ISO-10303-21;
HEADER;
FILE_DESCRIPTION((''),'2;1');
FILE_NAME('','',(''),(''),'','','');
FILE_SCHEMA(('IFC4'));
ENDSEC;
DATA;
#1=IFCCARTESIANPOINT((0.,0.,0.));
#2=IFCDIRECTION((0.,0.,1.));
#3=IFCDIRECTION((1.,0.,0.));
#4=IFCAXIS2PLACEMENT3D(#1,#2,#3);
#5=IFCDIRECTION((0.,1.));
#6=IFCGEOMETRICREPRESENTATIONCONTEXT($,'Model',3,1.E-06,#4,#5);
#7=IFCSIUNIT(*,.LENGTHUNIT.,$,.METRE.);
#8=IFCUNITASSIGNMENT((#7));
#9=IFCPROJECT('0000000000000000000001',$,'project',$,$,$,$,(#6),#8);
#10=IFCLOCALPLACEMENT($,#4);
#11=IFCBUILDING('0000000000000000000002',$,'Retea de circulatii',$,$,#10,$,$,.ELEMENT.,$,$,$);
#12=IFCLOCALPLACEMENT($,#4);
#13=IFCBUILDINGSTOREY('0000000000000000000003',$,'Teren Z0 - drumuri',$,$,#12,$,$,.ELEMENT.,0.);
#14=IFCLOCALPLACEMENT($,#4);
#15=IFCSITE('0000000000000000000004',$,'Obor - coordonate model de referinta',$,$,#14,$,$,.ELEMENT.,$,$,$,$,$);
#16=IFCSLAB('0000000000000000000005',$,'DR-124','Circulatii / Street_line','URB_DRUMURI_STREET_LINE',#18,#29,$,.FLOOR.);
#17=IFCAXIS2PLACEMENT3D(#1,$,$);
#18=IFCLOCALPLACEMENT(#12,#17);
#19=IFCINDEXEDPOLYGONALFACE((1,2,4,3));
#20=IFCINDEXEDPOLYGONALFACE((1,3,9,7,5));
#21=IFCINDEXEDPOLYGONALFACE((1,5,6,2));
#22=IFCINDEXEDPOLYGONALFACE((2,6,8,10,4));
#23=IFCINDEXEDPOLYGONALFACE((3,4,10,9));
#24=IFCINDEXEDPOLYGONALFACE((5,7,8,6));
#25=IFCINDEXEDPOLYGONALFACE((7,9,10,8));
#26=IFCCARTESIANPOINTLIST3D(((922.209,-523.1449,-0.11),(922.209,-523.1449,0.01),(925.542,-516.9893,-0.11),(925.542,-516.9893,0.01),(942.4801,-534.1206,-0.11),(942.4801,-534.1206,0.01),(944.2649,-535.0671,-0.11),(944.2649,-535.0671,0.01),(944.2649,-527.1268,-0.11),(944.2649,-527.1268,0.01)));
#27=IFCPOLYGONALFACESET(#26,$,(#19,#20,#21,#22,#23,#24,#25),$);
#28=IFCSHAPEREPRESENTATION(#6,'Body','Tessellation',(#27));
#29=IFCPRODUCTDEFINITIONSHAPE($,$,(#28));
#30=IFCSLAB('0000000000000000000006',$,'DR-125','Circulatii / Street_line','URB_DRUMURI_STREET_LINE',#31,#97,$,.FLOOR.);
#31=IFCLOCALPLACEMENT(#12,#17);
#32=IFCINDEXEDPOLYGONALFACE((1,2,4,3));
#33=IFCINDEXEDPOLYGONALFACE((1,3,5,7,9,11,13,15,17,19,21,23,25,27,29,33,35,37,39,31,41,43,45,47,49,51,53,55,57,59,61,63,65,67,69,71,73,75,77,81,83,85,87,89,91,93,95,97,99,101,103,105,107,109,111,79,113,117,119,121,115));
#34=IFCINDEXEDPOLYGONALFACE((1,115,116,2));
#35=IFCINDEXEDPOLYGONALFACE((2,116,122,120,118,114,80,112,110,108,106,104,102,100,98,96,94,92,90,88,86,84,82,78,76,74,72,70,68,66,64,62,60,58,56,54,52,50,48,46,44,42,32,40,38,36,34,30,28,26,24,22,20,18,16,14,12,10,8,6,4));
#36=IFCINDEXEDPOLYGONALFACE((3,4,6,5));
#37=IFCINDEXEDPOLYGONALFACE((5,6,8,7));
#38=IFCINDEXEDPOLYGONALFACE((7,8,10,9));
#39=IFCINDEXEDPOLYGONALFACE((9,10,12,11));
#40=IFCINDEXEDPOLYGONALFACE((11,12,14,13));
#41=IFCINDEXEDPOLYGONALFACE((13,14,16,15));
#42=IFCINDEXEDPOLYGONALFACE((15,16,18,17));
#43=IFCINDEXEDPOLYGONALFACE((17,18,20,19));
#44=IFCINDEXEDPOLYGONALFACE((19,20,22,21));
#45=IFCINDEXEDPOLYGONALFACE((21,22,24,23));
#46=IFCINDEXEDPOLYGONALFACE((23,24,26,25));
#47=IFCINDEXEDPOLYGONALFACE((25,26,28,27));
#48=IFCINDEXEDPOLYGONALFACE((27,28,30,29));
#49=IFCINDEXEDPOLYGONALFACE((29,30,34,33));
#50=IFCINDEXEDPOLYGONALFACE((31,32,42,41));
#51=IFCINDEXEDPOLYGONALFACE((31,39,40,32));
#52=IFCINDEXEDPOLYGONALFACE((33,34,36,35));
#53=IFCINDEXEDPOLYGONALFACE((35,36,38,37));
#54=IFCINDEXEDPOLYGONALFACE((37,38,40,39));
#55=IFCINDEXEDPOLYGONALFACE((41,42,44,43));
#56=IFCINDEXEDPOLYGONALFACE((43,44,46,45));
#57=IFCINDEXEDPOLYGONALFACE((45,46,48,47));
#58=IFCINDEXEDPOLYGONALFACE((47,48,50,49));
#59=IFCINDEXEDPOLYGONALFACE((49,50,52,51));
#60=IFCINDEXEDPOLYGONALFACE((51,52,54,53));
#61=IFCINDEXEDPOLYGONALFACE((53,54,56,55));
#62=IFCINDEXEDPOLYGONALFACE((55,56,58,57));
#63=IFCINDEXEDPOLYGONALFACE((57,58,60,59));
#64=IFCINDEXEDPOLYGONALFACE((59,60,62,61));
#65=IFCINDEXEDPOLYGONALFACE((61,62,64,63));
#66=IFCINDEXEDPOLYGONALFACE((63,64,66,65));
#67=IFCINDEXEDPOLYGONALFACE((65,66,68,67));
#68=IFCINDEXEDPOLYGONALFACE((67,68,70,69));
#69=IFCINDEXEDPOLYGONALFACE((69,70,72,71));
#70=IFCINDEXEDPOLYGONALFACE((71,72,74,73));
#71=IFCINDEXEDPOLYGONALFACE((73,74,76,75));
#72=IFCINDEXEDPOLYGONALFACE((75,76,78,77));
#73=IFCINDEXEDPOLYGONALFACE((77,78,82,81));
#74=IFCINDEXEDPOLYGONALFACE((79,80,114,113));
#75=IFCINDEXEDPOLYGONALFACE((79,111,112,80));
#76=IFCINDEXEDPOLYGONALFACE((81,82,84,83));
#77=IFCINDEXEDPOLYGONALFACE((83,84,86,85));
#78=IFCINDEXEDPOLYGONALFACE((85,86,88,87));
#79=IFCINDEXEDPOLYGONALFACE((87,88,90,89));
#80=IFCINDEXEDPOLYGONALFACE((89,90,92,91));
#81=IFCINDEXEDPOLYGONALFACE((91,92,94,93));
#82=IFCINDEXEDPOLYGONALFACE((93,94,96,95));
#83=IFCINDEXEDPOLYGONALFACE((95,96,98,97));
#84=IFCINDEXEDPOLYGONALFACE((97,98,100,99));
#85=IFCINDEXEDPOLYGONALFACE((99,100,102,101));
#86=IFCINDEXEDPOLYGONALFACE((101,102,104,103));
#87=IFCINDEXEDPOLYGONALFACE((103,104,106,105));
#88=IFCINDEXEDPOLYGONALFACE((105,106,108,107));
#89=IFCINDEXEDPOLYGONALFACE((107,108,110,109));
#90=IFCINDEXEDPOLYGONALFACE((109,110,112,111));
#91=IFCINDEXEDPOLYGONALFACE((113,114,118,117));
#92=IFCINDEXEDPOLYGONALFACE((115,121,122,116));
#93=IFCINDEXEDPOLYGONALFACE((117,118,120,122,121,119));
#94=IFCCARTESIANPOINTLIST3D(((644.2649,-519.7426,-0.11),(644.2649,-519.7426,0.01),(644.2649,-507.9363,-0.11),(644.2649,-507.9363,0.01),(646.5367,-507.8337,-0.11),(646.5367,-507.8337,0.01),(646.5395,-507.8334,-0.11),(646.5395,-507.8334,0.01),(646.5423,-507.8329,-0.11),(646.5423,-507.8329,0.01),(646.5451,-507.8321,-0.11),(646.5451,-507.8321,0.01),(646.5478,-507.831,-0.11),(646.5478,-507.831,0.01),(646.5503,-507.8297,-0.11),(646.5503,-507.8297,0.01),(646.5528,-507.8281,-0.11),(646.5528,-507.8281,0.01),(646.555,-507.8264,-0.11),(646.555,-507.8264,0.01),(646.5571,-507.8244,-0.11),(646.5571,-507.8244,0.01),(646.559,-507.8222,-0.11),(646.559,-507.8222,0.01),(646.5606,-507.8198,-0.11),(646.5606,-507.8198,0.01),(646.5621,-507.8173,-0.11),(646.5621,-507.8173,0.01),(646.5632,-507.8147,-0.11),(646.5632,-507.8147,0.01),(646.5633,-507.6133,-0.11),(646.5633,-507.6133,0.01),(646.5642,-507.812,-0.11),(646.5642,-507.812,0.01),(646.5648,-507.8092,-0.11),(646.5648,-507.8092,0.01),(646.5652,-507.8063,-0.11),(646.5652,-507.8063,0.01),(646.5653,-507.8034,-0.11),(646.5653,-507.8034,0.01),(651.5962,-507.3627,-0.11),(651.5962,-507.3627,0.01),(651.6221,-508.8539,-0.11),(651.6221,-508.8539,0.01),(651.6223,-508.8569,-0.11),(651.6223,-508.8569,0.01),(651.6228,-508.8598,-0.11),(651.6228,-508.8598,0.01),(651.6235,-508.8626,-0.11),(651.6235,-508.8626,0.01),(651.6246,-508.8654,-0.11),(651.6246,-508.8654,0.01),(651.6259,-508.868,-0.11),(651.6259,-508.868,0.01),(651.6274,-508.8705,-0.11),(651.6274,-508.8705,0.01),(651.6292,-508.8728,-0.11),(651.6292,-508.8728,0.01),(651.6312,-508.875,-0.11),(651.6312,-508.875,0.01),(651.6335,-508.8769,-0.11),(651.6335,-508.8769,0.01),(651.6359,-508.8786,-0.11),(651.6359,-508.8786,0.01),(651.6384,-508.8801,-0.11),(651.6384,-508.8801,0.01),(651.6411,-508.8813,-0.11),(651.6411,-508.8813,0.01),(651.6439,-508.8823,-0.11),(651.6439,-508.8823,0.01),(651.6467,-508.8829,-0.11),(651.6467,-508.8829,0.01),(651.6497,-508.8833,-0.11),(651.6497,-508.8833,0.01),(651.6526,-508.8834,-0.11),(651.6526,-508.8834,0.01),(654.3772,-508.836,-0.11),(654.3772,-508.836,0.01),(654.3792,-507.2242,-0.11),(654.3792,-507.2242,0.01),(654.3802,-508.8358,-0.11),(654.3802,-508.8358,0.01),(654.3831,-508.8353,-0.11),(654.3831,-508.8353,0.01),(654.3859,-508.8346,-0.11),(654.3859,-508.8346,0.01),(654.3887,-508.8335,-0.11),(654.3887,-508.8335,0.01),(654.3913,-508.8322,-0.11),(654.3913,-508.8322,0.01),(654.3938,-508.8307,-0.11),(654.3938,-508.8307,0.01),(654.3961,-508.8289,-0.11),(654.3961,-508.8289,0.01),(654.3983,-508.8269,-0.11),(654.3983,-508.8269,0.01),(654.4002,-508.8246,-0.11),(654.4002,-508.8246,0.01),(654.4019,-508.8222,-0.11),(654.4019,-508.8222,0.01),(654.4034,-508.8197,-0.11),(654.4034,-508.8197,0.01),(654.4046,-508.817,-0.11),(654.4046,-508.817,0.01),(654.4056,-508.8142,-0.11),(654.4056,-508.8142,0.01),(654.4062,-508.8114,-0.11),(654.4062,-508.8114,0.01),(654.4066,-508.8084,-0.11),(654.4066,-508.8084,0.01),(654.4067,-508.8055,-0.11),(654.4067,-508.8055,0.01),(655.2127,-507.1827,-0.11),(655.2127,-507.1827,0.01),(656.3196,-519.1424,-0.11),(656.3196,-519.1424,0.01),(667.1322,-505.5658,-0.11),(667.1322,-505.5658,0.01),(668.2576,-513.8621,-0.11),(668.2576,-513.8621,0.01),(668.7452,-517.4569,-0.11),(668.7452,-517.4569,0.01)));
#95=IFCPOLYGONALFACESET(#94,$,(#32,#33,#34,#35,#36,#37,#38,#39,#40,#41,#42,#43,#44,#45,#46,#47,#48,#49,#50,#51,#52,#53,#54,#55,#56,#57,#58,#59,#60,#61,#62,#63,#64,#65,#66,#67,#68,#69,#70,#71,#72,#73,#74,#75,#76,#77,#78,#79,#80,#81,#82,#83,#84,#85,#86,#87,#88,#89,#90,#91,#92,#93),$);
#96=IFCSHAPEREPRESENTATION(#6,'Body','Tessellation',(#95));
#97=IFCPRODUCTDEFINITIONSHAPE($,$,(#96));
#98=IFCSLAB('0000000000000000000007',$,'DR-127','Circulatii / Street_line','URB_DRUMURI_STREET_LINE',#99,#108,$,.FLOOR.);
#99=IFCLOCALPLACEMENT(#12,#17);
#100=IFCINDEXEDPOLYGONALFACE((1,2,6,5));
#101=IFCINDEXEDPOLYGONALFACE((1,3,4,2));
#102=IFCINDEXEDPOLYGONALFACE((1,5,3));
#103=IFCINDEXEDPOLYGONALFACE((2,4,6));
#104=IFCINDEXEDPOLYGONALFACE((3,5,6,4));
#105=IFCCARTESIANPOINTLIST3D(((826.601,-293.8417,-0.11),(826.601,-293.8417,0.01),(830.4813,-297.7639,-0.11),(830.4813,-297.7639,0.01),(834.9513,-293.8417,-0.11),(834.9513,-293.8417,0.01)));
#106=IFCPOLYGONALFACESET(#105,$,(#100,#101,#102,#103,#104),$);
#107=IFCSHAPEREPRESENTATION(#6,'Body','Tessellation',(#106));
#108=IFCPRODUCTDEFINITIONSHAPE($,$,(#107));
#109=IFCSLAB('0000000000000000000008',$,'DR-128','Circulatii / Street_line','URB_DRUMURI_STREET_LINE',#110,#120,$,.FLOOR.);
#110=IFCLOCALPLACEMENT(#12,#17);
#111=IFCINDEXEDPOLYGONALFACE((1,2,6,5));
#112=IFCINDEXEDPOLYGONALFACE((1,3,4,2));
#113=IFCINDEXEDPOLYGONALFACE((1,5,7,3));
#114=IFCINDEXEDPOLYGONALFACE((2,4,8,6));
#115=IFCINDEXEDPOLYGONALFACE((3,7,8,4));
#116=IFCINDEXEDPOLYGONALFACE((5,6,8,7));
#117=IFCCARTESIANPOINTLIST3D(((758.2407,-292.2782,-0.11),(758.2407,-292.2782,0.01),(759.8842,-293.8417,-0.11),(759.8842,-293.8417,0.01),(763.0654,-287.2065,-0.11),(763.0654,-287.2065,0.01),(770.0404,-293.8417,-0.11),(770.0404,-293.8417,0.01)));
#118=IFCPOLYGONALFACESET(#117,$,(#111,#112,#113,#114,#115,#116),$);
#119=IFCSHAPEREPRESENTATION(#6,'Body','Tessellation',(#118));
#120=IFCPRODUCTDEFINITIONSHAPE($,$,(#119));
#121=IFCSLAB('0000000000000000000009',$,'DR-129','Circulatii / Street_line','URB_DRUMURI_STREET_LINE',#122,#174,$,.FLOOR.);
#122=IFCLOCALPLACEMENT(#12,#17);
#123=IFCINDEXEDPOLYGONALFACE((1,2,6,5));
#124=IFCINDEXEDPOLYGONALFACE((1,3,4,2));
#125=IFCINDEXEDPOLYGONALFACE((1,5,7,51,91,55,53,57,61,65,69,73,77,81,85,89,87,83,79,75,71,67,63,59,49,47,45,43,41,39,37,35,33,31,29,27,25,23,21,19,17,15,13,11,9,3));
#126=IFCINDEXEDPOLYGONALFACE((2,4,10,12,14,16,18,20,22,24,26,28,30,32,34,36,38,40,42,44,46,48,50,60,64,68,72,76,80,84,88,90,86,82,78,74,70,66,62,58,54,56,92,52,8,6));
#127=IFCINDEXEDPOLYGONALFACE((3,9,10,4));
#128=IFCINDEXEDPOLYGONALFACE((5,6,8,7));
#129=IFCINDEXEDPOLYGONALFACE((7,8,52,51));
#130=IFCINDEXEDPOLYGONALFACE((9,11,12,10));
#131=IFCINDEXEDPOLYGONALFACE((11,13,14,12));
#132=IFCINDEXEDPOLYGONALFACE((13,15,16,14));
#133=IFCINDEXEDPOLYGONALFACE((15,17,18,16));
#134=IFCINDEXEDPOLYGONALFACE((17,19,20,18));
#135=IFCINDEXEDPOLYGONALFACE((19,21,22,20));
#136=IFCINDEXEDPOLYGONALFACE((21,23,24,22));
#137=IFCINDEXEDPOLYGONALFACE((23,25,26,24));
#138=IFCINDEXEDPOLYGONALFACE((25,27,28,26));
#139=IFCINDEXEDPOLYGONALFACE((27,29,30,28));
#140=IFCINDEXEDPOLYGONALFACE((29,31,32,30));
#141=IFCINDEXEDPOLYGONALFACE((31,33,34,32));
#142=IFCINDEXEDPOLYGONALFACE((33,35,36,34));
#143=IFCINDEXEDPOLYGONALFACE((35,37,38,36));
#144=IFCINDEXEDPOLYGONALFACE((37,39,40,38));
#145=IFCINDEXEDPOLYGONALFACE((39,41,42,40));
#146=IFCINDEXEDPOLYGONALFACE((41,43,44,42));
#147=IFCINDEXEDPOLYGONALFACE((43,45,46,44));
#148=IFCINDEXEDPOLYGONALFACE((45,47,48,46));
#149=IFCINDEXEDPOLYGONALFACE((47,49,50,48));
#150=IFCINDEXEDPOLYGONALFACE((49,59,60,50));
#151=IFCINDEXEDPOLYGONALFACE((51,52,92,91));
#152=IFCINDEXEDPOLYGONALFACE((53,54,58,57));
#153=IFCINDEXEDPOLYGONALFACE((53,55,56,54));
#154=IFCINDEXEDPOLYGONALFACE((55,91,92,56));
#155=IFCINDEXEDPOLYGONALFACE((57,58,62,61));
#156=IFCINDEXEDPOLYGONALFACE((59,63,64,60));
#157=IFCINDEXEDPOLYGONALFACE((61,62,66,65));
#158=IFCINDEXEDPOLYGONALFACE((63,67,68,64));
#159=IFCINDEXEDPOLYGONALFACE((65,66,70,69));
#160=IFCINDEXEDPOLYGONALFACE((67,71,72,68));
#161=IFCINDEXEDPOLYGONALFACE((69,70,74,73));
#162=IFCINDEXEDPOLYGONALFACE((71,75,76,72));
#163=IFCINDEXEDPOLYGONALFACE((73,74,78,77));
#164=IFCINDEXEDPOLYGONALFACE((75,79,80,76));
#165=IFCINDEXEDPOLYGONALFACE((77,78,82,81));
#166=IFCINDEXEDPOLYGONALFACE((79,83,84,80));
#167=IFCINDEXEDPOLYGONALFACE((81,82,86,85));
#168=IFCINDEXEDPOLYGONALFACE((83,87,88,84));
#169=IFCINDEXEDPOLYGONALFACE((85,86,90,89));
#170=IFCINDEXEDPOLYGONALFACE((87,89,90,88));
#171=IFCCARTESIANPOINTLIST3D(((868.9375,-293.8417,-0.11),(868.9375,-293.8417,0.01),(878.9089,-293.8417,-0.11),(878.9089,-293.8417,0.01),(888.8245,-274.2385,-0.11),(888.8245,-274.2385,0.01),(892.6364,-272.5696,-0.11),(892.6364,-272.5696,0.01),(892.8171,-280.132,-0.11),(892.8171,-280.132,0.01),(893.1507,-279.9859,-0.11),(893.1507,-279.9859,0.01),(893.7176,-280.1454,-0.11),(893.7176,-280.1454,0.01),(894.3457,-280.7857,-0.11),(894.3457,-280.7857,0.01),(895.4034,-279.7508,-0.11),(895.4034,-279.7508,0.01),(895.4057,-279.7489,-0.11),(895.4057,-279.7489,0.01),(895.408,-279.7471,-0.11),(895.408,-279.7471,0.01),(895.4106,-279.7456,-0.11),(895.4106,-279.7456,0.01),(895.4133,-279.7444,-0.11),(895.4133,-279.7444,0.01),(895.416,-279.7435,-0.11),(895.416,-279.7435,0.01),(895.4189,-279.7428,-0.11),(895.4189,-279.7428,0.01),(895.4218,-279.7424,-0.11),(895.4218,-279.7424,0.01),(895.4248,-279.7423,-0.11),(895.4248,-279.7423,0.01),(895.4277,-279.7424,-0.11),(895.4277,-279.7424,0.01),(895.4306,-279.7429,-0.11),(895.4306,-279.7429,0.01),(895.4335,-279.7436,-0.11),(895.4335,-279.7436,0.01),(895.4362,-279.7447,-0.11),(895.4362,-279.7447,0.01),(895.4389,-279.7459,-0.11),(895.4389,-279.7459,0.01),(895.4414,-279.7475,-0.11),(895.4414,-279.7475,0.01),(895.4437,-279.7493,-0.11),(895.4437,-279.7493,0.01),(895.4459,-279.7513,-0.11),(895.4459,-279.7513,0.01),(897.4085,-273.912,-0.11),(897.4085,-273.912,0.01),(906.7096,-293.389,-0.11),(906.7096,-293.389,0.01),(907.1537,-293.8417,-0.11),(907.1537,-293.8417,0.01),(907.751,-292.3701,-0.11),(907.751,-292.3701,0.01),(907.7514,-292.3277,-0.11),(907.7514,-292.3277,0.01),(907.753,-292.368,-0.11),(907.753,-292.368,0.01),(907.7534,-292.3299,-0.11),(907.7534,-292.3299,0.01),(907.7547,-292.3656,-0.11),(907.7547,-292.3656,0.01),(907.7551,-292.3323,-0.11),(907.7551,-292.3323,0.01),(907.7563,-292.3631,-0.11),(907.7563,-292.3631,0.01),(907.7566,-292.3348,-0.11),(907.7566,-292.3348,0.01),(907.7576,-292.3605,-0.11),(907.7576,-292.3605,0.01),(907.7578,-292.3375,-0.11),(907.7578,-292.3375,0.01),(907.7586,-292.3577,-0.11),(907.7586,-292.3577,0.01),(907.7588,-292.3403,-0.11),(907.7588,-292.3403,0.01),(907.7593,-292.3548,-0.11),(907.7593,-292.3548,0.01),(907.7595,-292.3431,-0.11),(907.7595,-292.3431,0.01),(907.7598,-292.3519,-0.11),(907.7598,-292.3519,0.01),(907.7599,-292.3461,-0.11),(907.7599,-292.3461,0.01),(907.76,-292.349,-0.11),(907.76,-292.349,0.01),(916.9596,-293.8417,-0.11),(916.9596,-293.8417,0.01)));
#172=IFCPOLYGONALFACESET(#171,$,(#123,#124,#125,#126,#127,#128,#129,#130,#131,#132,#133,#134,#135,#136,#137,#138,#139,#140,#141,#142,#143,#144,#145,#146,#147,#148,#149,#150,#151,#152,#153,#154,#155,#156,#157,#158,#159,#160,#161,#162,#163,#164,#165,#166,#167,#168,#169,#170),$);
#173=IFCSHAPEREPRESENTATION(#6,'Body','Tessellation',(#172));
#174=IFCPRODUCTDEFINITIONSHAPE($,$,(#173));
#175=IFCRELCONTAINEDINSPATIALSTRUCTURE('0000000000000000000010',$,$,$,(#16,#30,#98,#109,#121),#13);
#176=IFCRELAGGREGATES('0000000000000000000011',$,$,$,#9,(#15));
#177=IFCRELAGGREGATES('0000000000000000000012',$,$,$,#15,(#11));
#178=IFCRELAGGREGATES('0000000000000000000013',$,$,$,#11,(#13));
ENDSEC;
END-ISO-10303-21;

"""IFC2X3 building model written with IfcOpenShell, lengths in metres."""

from ifc_helpers import new_model, si_unit, direction, frame, origin_with_axes, place, context, project, spatial, polyline, outline, extrude, element, save


model = new_model("IFC2X3")

# Units and contexts
model_context = context("Model", 3, precision=1e-06, world=origin_with_axes(), true_north=direction((0.0, 1.0)))
ifc_project = project(units=[si_unit("LENGTHUNIT", "METRE")], contexts=[model_context])

# Site, building, storey
site_placement = place(None, origin_with_axes())
site = spatial("IfcSite", under=ifc_project, at=site_placement, Name="Obor - coordonate model de referinta", CompositionType="ELEMENT")
building_placement = place(None, origin_with_axes())
building = spatial("IfcBuilding", under=site, at=building_placement, Name="Retea de circulatii", CompositionType="ELEMENT")
storey_placement = place(None, origin_with_axes())
storey = spatial("IfcBuildingStorey", under=building, at=storey_placement, Name="Teren Z0 - drumuri", CompositionType="ELEMENT", Elevation=0.0)

# Slabs
slab_1_placement = place(None, origin_with_axes())
element("IfcSlab", 1, at=slab_1_placement, inside=storey, Name="DR-124", Description="Circulatii / Street_line", ObjectType="URB_DRUMURI_STREET_LINE", PredefinedType="FLOOR", context=model_context, shape_type="SweptSolid", body=[
    extrude(outline(polyline([(925.542, -516.9893), (922.209, -523.1449), (942.4801, -534.1206), (944.2649, -535.0671), (944.2649, -527.1268), (925.542, -516.9893)])), frame((0.0, 0.0, -0.11), z_axis=(0.0, 0.0, 1.0), x_axis=(1.0, 0.0, 0.0)), (0.0, 0.0, 1.0), 0.12),
])
slab_2_placement = place(None, origin_with_axes())
element("IfcSlab", 2, at=slab_2_placement, inside=storey, Name="DR-125", Description="Circulatii / Street_line", ObjectType="URB_DRUMURI_STREET_LINE", PredefinedType="FLOOR", context=model_context, shape_type="SweptSolid", body=[
    extrude(outline(polyline([(646.5423, -507.8329), (646.5395, -507.8334), (646.5367, -507.8337), (644.2649, -507.9363), (644.2649, -519.7426), (656.3196, -519.1424), (668.7452, -517.4569), (668.2576, -513.8621), (667.1322, -505.5658), (655.2127, -507.1827), (654.3792, -507.2242), (654.4067, -508.8055), (654.4066, -508.8084), (654.4062, -508.8114), (654.4056, -508.8142), (654.4046, -508.817), (654.4034, -508.8197), (654.4019, -508.8222), (654.4002, -508.8246), (654.3983, -508.8269), (654.3961, -508.8289), (654.3938, -508.8307), (654.3913, -508.8322), (654.3887, -508.8335), (654.3859, -508.8346), (654.3831, -508.8353), (654.3802, -508.8358), (654.3772, -508.836), (651.6526, -508.8834), (651.6497, -508.8833), (651.6467, -508.8829), (651.6439, -508.8823), (651.6411, -508.8813), (651.6384, -508.8801), (651.6359, -508.8786), (651.6335, -508.8769), (651.6312, -508.875), (651.6292, -508.8728), (651.6274, -508.8705), (651.6259, -508.868), (651.6246, -508.8654), (651.6235, -508.8626), (651.6228, -508.8598), (651.6223, -508.8569), (651.6221, -508.8539), (651.5962, -507.3627), (646.5633, -507.6133), (646.5653, -507.8034), (646.5652, -507.8063), (646.5648, -507.8092), (646.5642, -507.812), (646.5632, -507.8147), (646.5621, -507.8173), (646.5606, -507.8198), (646.559, -507.8222), (646.5571, -507.8244), (646.555, -507.8264), (646.5528, -507.8281), (646.5503, -507.8297), (646.5478, -507.831), (646.5451, -507.8321), (646.5423, -507.8329)])), frame((0.0, 0.0, -0.11), z_axis=(0.0, 0.0, 1.0), x_axis=(1.0, 0.0, 0.0)), (0.0, 0.0, 1.0), 0.12),
])
slab_3_placement = place(None, origin_with_axes())
element("IfcSlab", 3, at=slab_3_placement, inside=storey, Name="DR-127", Description="Circulatii / Street_line", ObjectType="URB_DRUMURI_STREET_LINE", PredefinedType="FLOOR", context=model_context, shape_type="SweptSolid", body=[
    extrude(outline(polyline([(834.9513, -293.8417), (826.601, -293.8417), (830.4813, -297.7639), (834.9513, -293.8417)])), frame((0.0, 0.0, -0.11), z_axis=(0.0, 0.0, 1.0), x_axis=(1.0, 0.0, 0.0)), (0.0, 0.0, 1.0), 0.12),
])
slab_4_placement = place(None, origin_with_axes())
element("IfcSlab", 4, at=slab_4_placement, inside=storey, Name="DR-128", Description="Circulatii / Street_line", ObjectType="URB_DRUMURI_STREET_LINE", PredefinedType="FLOOR", context=model_context, shape_type="SweptSolid", body=[
    extrude(outline(polyline([(770.0404, -293.8417), (763.0654, -287.2065), (758.2407, -292.2782), (759.8842, -293.8417), (770.0404, -293.8417)])), frame((0.0, 0.0, -0.11), z_axis=(0.0, 0.0, 1.0), x_axis=(1.0, 0.0, 0.0)), (0.0, 0.0, 1.0), 0.12),
])
slab_5_placement = place(None, origin_with_axes())
element("IfcSlab", 5, at=slab_5_placement, inside=storey, Name="DR-129", Description="Circulatii / Street_line", ObjectType="URB_DRUMURI_STREET_LINE", PredefinedType="FLOOR", context=model_context, shape_type="SweptSolid", body=[
    extrude(outline(polyline([(897.4085, -273.912), (892.6364, -272.5696), (888.8245, -274.2385), (868.9375, -293.8417), (878.9089, -293.8417), (892.8171, -280.132), (893.1507, -279.9859), (893.7176, -280.1454), (894.3457, -280.7857), (895.4034, -279.7508), (895.4057, -279.7489), (895.408, -279.7471), (895.4106, -279.7456), (895.4133, -279.7444), (895.416, -279.7435), (895.4189, -279.7428), (895.4218, -279.7424), (895.4248, -279.7423), (895.4277, -279.7424), (895.4306, -279.7429), (895.4335, -279.7436), (895.4362, -279.7447), (895.4389, -279.7459), (895.4414, -279.7475), (895.4437, -279.7493), (895.4459, -279.7513), (907.7514, -292.3277), (907.7534, -292.3299), (907.7551, -292.3323), (907.7566, -292.3348), (907.7578, -292.3375), (907.7588, -292.3403), (907.7595, -292.3431), (907.7599, -292.3461), (907.76, -292.349), (907.7598, -292.3519), (907.7593, -292.3548), (907.7586, -292.3577), (907.7576, -292.3605), (907.7563, -292.3631), (907.7547, -292.3656), (907.753, -292.368), (907.751, -292.3701), (906.7096, -293.389), (907.1537, -293.8417), (916.9596, -293.8417), (897.4085, -273.912)])), frame((0.0, 0.0, -0.11), z_axis=(0.0, 0.0, 1.0), x_axis=(1.0, 0.0, 0.0)), (0.0, 0.0, 1.0), 0.12),
])

save(model, "model.ifc")
